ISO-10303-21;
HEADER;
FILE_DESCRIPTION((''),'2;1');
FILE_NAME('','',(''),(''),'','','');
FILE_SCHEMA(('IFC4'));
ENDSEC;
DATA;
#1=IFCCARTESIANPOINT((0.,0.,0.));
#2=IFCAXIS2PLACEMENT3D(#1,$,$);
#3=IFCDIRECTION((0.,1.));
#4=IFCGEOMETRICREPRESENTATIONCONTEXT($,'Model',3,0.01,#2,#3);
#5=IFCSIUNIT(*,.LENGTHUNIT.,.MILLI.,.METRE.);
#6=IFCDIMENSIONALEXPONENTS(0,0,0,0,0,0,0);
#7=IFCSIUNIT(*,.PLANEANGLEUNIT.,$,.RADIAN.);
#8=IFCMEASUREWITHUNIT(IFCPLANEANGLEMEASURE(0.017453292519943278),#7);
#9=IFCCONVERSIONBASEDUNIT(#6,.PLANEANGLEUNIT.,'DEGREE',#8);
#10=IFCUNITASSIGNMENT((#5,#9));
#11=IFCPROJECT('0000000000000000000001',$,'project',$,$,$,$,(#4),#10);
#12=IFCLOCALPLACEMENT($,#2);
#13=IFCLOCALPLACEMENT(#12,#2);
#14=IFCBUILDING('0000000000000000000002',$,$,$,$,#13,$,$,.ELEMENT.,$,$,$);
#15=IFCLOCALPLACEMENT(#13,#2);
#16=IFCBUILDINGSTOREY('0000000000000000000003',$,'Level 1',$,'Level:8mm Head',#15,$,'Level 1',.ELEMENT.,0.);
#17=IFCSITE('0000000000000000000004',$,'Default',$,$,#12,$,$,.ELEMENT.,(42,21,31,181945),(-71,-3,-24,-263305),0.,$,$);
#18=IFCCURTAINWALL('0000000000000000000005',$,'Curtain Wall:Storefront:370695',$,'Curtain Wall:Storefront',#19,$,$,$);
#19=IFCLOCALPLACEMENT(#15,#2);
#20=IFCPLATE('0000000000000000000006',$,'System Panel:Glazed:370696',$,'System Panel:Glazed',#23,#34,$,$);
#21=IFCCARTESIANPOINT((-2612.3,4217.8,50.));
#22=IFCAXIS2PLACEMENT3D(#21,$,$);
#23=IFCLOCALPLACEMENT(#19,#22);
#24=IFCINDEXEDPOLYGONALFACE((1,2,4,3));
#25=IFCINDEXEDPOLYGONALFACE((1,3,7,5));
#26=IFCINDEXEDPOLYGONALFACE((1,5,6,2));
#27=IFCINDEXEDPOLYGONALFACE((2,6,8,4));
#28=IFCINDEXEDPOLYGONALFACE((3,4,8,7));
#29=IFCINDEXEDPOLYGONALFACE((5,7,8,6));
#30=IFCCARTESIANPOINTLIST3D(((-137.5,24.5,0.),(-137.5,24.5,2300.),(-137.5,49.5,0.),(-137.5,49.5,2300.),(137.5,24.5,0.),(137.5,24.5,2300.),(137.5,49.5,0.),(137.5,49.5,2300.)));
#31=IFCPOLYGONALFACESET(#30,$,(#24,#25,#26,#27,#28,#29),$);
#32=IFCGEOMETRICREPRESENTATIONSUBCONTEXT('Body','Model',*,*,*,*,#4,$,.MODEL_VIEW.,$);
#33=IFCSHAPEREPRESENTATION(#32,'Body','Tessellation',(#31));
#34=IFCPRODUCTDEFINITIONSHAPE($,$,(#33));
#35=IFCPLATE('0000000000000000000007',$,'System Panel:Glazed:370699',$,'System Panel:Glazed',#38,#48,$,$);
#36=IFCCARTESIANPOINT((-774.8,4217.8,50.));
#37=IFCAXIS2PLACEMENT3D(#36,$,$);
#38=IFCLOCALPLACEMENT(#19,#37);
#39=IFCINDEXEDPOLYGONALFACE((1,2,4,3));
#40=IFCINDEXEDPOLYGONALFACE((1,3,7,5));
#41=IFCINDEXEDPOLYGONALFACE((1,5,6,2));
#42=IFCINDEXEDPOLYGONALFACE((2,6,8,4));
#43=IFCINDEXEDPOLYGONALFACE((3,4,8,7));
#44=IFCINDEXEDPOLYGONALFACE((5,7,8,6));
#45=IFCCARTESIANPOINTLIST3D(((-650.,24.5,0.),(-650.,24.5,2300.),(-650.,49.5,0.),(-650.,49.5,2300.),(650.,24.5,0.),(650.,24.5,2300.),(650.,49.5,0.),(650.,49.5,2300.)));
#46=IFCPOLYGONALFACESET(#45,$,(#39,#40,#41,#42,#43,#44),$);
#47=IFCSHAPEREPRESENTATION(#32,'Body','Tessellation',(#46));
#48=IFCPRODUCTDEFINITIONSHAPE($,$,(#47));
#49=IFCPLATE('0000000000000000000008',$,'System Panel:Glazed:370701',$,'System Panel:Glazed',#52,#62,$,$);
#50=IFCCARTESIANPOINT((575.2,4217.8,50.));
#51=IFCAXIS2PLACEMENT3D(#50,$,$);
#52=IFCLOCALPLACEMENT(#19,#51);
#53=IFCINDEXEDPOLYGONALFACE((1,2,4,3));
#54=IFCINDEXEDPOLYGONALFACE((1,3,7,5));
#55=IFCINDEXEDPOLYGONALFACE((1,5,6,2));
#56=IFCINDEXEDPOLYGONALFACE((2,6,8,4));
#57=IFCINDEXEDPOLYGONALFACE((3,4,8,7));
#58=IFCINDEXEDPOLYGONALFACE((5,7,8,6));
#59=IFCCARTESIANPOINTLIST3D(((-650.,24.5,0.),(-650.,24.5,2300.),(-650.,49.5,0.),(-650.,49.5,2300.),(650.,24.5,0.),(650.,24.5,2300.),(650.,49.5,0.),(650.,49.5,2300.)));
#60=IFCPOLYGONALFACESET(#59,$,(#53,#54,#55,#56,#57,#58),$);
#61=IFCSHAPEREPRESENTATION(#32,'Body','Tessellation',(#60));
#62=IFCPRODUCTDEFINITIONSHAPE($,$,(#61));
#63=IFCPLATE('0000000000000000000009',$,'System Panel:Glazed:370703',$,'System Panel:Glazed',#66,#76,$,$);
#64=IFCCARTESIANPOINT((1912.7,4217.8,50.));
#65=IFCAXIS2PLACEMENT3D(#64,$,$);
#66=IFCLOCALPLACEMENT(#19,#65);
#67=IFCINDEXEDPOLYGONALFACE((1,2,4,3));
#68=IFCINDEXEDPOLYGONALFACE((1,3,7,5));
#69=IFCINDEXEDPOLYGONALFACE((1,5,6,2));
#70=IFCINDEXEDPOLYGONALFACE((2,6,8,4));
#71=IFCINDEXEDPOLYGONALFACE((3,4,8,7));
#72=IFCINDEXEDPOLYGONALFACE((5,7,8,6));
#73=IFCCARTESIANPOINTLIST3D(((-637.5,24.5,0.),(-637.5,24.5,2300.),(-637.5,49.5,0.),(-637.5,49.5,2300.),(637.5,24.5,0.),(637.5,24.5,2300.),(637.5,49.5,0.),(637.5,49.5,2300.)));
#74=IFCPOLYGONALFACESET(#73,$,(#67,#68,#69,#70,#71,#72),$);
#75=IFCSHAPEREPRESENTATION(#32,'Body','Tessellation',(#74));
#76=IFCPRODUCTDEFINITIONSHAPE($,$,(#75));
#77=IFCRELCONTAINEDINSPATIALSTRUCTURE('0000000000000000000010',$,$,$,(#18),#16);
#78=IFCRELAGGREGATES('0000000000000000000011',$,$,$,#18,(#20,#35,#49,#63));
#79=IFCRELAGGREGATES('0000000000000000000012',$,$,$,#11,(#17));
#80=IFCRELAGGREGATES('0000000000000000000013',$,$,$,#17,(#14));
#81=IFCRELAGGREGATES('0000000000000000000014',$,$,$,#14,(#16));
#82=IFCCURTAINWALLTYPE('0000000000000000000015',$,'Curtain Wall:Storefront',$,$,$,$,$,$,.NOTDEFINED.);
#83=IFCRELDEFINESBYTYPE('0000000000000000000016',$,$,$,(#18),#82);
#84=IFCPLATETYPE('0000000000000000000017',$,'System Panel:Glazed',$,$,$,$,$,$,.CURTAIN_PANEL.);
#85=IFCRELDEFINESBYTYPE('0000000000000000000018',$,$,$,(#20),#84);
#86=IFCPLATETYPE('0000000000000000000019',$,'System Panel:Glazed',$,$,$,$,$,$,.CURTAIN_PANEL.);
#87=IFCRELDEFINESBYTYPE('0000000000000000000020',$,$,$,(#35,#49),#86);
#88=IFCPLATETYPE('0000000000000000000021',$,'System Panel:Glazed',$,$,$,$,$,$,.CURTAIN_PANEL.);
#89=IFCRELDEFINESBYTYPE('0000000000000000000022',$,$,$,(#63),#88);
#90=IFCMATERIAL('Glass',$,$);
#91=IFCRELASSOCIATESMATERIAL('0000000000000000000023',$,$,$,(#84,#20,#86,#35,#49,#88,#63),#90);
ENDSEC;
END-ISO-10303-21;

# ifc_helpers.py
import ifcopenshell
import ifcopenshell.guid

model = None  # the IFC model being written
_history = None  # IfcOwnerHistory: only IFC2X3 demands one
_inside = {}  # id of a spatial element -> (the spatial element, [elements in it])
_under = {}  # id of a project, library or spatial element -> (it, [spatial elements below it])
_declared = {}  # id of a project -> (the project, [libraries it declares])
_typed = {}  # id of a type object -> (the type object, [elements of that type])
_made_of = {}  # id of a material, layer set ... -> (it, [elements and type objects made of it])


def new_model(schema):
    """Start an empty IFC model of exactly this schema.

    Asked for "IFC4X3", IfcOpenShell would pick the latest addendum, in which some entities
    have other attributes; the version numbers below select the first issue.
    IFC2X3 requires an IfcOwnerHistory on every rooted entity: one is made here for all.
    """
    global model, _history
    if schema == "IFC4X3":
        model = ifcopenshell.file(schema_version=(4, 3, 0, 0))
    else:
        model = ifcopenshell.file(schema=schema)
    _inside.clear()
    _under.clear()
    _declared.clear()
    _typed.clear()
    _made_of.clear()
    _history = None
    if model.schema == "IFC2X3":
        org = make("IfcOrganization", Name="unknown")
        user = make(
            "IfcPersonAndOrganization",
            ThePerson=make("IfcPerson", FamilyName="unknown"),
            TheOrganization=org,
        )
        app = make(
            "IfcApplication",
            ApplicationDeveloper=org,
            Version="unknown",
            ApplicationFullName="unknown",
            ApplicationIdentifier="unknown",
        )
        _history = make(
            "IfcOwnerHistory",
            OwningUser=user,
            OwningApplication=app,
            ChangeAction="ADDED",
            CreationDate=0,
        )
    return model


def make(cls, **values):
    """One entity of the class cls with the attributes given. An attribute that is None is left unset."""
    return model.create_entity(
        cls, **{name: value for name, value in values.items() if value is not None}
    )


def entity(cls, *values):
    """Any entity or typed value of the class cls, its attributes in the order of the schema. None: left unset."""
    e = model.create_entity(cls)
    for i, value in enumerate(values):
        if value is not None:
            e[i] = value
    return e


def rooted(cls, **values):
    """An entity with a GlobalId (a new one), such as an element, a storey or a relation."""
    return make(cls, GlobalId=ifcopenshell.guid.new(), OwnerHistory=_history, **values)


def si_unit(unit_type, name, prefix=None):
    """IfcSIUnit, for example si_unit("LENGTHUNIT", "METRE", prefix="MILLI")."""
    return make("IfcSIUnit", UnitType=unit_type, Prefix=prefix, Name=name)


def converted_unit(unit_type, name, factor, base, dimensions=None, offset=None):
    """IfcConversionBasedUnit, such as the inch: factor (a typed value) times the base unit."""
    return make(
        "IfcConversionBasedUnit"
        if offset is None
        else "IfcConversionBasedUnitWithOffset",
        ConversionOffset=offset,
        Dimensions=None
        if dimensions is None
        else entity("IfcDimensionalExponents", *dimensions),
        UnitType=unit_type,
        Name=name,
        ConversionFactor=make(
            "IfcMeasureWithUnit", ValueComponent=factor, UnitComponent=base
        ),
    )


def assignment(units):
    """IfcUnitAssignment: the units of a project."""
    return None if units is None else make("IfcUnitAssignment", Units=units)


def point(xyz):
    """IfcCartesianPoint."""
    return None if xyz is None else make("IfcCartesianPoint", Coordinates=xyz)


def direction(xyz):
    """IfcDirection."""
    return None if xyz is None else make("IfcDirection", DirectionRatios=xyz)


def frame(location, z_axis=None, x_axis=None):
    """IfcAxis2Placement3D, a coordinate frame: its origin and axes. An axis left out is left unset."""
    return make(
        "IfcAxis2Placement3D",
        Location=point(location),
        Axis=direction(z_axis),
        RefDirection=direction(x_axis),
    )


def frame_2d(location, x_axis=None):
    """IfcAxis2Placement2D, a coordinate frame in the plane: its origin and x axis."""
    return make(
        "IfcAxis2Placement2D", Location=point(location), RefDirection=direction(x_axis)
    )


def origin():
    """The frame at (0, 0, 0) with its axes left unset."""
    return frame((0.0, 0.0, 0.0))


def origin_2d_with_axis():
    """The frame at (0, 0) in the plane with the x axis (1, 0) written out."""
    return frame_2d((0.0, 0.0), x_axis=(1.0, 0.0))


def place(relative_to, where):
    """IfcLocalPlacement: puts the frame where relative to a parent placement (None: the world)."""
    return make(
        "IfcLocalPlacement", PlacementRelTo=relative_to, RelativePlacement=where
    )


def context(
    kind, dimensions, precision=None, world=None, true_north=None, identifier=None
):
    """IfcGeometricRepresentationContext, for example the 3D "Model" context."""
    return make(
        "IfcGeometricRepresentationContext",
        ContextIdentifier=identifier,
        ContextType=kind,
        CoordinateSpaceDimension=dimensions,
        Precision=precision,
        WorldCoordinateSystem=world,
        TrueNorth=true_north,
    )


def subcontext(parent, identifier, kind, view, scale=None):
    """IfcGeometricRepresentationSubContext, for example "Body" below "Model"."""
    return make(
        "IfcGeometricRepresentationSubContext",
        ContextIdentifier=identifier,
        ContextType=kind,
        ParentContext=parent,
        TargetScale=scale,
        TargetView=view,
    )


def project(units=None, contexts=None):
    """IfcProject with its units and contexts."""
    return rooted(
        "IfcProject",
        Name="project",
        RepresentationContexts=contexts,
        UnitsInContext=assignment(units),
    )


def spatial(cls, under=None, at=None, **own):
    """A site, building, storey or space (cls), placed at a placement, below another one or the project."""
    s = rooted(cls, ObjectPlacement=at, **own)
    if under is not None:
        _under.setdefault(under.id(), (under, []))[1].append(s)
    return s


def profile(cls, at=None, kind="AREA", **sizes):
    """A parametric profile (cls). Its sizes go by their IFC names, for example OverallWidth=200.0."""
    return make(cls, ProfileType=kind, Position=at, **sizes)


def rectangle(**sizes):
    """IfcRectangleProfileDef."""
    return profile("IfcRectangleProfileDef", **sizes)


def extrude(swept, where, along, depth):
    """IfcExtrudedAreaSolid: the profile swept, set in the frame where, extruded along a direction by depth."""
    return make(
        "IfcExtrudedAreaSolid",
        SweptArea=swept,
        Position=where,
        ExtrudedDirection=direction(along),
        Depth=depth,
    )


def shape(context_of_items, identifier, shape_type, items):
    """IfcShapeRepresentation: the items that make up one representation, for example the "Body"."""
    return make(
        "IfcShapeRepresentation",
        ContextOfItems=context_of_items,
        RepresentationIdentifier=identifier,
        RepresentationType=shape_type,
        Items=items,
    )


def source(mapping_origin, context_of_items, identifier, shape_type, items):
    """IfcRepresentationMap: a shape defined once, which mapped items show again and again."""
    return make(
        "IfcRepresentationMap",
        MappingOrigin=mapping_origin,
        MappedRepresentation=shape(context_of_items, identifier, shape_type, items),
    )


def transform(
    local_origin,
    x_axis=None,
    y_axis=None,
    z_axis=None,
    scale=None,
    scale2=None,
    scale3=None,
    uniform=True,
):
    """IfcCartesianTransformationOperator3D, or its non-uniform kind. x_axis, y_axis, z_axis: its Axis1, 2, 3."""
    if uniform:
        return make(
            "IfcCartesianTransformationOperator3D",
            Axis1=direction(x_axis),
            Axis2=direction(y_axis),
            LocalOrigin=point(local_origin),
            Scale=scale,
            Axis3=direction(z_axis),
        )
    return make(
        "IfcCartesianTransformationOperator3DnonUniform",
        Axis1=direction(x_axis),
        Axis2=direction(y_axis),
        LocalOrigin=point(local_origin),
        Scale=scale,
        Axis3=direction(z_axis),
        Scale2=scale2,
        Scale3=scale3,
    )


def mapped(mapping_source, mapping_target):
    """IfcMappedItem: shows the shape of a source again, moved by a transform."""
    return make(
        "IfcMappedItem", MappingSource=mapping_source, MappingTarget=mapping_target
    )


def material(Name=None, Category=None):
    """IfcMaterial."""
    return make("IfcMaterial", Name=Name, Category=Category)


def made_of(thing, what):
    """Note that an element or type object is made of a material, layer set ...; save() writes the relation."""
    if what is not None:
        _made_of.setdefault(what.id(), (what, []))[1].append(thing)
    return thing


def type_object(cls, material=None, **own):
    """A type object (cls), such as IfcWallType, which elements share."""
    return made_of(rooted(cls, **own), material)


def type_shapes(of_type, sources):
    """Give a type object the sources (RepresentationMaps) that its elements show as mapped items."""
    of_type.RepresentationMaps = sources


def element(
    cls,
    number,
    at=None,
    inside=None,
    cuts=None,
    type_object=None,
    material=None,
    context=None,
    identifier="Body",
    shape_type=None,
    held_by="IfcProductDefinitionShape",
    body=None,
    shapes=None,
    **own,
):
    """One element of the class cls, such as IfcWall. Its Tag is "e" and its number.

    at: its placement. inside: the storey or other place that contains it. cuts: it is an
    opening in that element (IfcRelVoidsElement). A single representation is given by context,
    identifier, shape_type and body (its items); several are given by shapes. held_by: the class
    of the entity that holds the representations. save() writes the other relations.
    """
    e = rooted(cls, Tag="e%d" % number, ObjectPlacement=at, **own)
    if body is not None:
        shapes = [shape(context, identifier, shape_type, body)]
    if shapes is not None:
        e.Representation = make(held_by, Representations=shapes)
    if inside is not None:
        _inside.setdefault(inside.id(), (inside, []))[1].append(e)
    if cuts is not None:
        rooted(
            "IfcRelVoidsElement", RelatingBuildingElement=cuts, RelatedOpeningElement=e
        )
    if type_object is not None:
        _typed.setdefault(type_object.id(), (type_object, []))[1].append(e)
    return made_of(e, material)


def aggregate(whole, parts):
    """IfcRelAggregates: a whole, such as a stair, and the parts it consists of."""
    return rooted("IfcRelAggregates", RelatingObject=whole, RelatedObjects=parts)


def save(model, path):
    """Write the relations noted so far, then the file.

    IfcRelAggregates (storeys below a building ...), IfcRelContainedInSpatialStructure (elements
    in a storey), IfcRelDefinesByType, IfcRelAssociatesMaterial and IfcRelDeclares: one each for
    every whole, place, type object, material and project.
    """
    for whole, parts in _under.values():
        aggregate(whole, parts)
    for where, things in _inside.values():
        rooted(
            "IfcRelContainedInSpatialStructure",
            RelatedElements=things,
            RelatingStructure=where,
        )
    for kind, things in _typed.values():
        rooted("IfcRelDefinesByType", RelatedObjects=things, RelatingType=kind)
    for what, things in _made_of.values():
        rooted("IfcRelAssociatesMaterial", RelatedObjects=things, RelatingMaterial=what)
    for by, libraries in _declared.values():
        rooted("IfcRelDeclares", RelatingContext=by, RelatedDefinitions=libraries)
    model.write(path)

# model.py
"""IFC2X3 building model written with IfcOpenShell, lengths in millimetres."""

from ifc_helpers import new_model, entity, si_unit, converted_unit, direction, frame, origin, origin_2d_with_axis, place, context, subcontext, project, spatial, rectangle, extrude, source, transform, mapped, material, type_object, type_shapes, element, aggregate, save


model = new_model("IFC2X3")

# Units and contexts
model_context = context("Model", 3, precision=0.01, world=origin(), true_north=direction((0.0, 1.0)))
body_context = subcontext(model_context, "Body", "Model", "MODEL_VIEW")
ifc_project = project(units=[si_unit("LENGTHUNIT", "METRE", prefix="MILLI"), converted_unit("PLANEANGLEUNIT", "DEGREE", entity("IfcPlaneAngleMeasure", 0.017453292519943278), si_unit("PLANEANGLEUNIT", "RADIAN"), dimensions=[0, 0, 0, 0, 0, 0, 0])], contexts=[model_context])

# Site, building, storey
site_placement = place(None, origin())
site = spatial("IfcSite", under=ifc_project, at=site_placement, Name="Default", CompositionType="ELEMENT", RefLatitude=(42, 21, 31, 181945), RefLongitude=(-71, -3, -24, -263305), RefElevation=0.0)
building_placement = place(site_placement, origin())
building = spatial("IfcBuilding", under=site, at=building_placement, CompositionType="ELEMENT")
storey_placement = place(building_placement, origin())
storey = spatial("IfcBuildingStorey", under=building, at=storey_placement, Name="Level 1", ObjectType="Level:8mm Head", LongName="Level 1", CompositionType="ELEMENT", Elevation=0.0)

# Curtain wall, plates
curtain_wall_type = type_object("IfcCurtainWallType", Name="Curtain Wall:Storefront", PredefinedType="NOTDEFINED")
curtain_wall_placement = place(storey_placement, origin())
curtain_wall = element("IfcCurtainWall", 1, at=curtain_wall_placement, inside=storey, type_object=curtain_wall_type, Name="Curtain Wall:Storefront:370695", ObjectType="Curtain Wall:Storefront")
ifc_material_1 = material(Name="Glass")
plate_type_1 = type_object("IfcPlateType", Name="System Panel:Glazed", PredefinedType="CURTAIN_PANEL", material=ifc_material_1)
shared_shape_1 = source(origin(), body_context, "Body", "SweptSolid", [
    extrude(rectangle(XDim=25.0, YDim=275.0, at=origin_2d_with_axis()), frame((0.0, 37.0, 0.0), z_axis=(0.0, 0.0, 1.0), x_axis=(0.0, 1.0, 0.0)), (0.0, 0.0, 1.0), 2300.0),
])
type_shapes(plate_type_1, [shared_shape_1])
plate_1_placement = place(curtain_wall_placement, frame((-2612.3, 4217.8, 50.0)))
plate_1 = element("IfcPlate", 2, at=plate_1_placement, type_object=plate_type_1, material=ifc_material_1, Name="System Panel:Glazed:370696", ObjectType="System Panel:Glazed", context=body_context, shape_type="MappedRepresentation", body=[
    mapped(shared_shape_1, transform((0.0, 0.0, 0.0), scale=1.0)),
])
plate_type_2 = type_object("IfcPlateType", Name="System Panel:Glazed", PredefinedType="CURTAIN_PANEL", material=ifc_material_1)
shared_shape_2 = source(origin(), body_context, "Body", "SweptSolid", [
    extrude(rectangle(XDim=25.0, YDim=1300.0, at=origin_2d_with_axis()), frame((0.0, 37.0, 0.0), z_axis=(0.0, 0.0, 1.0), x_axis=(0.0, 1.0, 0.0)), (0.0, 0.0, 1.0), 2300.0),
])
type_shapes(plate_type_2, [shared_shape_2])
plate_2_placement = place(curtain_wall_placement, frame((-774.8, 4217.8, 50.0)))
plate_2 = element("IfcPlate", 3, at=plate_2_placement, type_object=plate_type_2, material=ifc_material_1, Name="System Panel:Glazed:370699", ObjectType="System Panel:Glazed", context=body_context, shape_type="MappedRepresentation", body=[
    mapped(shared_shape_2, transform((0.0, 0.0, 0.0), scale=1.0)),
])
plate_3_placement = place(curtain_wall_placement, frame((575.2, 4217.8, 50.0)))
plate_3 = element("IfcPlate", 4, at=plate_3_placement, type_object=plate_type_2, material=ifc_material_1, Name="System Panel:Glazed:370701", ObjectType="System Panel:Glazed", context=body_context, shape_type="MappedRepresentation", body=[
    mapped(shared_shape_2, transform((0.0, 0.0, 0.0), scale=1.0)),
])
plate_type_3 = type_object("IfcPlateType", Name="System Panel:Glazed", PredefinedType="CURTAIN_PANEL", material=ifc_material_1)
shared_shape_3 = source(origin(), body_context, "Body", "SweptSolid", [
    extrude(rectangle(XDim=25.0, YDim=1275.0, at=origin_2d_with_axis()), frame((0.0, 37.0, 0.0), z_axis=(0.0, 0.0, 1.0), x_axis=(0.0, 1.0, 0.0)), (0.0, 0.0, 1.0), 2300.0),
])
type_shapes(plate_type_3, [shared_shape_3])
plate_4_placement = place(curtain_wall_placement, frame((1912.7, 4217.8, 50.0)))
plate_4 = element("IfcPlate", 5, at=plate_4_placement, type_object=plate_type_3, material=ifc_material_1, Name="System Panel:Glazed:370703", ObjectType="System Panel:Glazed", context=body_context, shape_type="MappedRepresentation", body=[
    mapped(shared_shape_3, transform((0.0, 0.0, 0.0), scale=1.0)),
])

aggregate(curtain_wall, [plate_1, plate_2, plate_3, plate_4])

save(model, "model.ifc")
